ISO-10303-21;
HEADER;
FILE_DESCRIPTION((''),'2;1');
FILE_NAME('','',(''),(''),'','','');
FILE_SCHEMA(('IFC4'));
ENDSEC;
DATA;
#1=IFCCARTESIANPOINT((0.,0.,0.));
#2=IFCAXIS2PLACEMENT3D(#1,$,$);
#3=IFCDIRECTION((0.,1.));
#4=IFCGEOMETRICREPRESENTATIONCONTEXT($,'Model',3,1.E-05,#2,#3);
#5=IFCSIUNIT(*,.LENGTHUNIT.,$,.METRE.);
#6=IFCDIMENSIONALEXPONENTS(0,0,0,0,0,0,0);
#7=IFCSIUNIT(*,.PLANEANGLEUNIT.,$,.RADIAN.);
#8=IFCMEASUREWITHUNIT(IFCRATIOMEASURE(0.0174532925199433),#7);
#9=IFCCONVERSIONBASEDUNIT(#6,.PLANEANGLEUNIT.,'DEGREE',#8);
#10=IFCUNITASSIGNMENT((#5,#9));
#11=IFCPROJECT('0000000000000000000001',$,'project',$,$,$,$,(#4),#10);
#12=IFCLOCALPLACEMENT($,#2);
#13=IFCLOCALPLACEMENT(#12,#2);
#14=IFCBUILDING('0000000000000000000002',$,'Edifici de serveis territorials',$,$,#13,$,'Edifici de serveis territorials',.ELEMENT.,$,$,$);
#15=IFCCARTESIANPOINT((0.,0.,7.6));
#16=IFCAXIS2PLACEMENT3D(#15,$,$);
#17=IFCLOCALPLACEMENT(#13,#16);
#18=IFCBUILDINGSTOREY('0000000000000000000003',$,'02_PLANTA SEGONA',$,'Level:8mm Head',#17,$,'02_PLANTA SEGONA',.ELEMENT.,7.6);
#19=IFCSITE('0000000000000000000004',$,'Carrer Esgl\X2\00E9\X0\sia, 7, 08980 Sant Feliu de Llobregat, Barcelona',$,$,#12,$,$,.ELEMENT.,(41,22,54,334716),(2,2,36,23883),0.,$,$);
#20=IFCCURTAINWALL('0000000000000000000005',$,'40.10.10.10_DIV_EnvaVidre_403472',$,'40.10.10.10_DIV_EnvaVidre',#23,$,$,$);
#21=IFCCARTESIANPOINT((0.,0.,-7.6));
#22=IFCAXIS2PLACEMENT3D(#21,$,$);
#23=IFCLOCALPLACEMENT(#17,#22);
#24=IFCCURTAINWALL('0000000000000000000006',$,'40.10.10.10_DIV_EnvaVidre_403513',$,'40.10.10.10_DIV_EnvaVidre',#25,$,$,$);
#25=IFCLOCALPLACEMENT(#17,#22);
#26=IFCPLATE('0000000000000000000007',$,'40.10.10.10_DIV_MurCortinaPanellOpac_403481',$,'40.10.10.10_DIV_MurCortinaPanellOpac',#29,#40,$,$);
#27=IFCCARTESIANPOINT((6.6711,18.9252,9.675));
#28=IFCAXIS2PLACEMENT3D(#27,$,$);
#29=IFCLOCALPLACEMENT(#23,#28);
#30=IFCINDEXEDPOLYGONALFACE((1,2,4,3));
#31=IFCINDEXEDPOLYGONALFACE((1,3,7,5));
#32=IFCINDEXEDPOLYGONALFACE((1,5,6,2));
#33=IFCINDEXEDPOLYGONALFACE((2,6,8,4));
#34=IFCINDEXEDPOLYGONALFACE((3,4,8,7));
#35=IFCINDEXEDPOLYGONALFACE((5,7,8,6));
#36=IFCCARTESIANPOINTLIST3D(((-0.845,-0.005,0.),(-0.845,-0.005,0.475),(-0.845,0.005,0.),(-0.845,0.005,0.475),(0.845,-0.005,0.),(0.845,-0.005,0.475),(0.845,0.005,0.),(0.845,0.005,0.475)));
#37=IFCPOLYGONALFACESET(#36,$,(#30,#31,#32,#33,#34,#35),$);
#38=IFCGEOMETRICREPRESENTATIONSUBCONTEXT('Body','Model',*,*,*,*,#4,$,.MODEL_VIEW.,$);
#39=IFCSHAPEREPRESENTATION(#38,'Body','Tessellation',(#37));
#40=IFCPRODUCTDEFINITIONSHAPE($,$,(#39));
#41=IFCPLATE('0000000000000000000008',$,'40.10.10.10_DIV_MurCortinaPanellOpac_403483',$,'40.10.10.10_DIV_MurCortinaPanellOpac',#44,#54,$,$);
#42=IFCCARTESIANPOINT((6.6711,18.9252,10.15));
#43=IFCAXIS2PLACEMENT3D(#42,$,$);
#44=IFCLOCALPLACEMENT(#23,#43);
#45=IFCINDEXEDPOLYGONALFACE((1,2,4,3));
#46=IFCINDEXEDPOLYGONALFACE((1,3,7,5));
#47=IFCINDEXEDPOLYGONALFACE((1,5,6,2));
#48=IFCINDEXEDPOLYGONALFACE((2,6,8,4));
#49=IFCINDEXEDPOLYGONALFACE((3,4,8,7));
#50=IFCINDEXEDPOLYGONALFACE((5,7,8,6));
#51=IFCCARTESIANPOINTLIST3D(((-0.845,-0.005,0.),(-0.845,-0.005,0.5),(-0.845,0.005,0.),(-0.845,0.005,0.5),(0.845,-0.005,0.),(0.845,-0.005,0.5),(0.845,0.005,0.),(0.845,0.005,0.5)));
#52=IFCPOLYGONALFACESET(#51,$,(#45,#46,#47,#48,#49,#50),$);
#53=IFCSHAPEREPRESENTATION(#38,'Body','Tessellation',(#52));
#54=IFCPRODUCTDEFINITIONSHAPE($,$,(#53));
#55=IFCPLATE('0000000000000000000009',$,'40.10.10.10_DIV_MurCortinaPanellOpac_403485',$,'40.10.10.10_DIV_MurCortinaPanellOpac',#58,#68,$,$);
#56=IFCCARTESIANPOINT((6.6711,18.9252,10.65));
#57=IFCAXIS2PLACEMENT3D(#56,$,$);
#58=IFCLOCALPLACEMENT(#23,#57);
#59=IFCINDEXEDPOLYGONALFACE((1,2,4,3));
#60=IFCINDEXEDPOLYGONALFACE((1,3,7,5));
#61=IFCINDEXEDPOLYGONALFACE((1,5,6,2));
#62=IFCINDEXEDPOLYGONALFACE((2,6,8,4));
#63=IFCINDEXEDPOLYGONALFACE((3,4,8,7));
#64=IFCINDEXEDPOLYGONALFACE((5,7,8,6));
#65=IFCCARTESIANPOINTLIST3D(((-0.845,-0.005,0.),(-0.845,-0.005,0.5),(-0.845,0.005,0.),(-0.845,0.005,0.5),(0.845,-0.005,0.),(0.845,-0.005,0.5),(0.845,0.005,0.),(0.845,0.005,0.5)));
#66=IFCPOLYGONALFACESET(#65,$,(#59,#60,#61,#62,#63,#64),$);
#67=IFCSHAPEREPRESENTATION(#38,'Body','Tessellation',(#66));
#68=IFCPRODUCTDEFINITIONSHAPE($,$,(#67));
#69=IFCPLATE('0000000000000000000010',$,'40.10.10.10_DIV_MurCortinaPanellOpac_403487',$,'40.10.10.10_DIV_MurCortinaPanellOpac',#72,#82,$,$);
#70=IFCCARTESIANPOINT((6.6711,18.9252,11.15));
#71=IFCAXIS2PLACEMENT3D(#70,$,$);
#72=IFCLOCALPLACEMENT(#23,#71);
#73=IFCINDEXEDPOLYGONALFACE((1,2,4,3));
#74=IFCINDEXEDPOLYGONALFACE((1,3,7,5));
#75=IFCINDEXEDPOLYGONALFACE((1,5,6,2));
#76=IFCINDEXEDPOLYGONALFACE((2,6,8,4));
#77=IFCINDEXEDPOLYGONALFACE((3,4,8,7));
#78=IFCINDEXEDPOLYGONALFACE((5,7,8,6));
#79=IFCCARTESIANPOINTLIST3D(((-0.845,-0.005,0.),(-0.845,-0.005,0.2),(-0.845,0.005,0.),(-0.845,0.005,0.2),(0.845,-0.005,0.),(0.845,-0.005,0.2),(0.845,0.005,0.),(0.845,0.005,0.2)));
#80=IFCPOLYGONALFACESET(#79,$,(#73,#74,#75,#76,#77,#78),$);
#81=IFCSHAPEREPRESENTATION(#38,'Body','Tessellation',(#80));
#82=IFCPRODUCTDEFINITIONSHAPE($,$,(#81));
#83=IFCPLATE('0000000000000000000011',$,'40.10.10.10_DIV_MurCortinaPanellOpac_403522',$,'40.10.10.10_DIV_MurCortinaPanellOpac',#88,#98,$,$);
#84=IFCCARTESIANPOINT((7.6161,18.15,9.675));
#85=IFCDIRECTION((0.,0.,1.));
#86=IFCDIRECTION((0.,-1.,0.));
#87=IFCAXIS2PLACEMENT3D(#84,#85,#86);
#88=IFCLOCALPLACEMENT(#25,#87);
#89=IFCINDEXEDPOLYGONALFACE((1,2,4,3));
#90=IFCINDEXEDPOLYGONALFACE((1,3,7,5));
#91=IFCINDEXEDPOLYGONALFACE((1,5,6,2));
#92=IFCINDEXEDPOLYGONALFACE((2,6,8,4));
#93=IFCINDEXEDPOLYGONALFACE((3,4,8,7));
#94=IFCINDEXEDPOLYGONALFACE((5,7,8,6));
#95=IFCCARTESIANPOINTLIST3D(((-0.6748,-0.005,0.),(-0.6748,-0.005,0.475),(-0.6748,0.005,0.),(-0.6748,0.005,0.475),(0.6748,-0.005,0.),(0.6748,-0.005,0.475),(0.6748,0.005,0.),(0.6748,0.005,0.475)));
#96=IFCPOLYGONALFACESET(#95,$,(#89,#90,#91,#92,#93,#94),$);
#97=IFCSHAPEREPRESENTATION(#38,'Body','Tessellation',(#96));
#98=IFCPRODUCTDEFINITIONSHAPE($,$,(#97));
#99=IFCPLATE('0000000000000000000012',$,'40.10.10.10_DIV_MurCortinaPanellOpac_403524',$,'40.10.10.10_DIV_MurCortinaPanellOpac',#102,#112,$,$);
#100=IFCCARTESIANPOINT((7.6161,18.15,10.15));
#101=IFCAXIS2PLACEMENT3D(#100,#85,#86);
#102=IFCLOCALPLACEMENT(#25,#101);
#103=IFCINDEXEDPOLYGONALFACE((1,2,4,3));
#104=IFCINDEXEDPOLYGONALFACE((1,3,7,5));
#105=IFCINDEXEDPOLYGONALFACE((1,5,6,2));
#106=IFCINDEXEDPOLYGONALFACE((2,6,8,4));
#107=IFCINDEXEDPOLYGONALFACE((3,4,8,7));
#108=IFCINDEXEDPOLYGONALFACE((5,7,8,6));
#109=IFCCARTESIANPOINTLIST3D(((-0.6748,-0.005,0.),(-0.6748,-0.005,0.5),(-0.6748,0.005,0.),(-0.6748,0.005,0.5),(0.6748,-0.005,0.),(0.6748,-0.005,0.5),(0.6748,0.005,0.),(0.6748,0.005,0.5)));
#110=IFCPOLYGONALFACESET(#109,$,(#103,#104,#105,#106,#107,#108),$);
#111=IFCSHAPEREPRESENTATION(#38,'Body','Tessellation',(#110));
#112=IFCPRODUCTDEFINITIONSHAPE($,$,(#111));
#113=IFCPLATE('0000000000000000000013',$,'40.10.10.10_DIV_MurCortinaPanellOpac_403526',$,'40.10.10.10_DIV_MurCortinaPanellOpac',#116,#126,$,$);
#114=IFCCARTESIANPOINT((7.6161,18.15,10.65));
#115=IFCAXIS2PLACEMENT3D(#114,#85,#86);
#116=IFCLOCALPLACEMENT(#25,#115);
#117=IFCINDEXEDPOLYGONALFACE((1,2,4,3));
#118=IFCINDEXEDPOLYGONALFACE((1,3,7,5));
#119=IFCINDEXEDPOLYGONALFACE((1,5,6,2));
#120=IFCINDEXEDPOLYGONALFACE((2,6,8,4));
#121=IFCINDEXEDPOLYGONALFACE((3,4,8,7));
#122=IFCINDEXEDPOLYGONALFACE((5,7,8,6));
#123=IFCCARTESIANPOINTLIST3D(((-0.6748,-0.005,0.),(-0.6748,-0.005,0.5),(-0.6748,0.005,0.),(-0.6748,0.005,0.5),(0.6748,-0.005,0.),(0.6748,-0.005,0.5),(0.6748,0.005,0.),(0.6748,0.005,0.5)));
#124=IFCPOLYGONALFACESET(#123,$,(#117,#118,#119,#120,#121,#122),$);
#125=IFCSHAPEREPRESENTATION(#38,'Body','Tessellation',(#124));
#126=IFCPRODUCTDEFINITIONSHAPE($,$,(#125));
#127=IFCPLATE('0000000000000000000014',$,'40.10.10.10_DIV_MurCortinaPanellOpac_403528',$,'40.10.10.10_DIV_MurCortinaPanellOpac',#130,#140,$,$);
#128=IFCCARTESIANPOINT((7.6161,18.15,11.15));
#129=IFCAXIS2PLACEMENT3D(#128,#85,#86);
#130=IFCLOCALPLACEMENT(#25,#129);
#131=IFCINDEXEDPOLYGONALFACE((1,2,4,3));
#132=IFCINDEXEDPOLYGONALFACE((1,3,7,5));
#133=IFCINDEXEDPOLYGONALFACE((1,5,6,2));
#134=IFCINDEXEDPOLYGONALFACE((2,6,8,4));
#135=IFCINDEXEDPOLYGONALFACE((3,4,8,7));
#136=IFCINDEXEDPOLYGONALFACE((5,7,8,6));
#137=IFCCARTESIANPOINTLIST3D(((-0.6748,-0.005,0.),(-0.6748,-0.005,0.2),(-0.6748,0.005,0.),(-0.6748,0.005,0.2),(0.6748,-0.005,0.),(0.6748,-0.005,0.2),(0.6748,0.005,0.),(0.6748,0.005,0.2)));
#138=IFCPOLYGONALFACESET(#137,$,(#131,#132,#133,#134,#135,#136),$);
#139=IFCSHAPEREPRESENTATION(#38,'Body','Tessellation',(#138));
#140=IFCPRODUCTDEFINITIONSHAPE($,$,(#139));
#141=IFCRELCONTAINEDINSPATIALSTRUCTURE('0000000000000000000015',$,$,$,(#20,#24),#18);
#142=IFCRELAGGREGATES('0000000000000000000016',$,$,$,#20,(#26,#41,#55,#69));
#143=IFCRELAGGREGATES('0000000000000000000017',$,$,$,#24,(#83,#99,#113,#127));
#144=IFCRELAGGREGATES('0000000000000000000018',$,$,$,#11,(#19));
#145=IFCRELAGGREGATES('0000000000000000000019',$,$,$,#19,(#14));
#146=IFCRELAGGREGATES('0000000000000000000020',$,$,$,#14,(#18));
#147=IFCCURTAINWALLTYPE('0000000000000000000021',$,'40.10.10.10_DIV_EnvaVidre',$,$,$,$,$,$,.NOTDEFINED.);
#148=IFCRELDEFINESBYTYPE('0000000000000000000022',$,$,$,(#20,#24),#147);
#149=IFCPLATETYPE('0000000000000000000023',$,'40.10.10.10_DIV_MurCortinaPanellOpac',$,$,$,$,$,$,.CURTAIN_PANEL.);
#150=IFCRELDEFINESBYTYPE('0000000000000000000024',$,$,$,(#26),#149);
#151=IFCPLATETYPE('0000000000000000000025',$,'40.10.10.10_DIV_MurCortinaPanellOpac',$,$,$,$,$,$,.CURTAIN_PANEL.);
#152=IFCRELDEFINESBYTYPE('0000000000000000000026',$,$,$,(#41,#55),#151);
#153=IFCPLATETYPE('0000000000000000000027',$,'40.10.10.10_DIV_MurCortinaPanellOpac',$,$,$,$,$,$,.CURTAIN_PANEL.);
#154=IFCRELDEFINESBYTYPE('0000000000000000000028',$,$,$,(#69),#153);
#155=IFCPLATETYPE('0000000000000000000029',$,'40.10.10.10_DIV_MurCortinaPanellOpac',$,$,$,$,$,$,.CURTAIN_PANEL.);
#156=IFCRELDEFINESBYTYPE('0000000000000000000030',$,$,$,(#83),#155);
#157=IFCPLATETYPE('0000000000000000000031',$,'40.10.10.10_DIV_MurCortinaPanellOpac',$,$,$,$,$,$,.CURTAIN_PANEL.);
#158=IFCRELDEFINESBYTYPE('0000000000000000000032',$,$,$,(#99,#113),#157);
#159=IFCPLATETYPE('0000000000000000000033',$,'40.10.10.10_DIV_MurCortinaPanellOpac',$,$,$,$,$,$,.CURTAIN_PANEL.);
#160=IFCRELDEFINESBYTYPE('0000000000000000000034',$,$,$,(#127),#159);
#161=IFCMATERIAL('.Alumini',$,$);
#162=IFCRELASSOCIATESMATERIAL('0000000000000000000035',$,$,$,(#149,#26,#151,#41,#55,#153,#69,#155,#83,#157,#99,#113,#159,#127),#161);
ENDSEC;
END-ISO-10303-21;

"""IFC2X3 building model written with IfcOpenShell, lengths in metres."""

from ifc_helpers import new_model, entity, si_unit, converted_unit, direction, frame, origin, origin_2d_with_axis, place, context, subcontext, project, spatial, rectangle, extrude, source, transform, mapped, material, type_object, type_shapes, element, aggregate, save


model = new_model("IFC2X3")

# Units and contexts
model_context = context("Model", 3, precision=1e-05, world=origin(), true_north=direction((0.0, 1.0)))
body_context = subcontext(model_context, "Body", "Model", "MODEL_VIEW")
ifc_project = project(units=[si_unit("LENGTHUNIT", "METRE"), converted_unit("PLANEANGLEUNIT", "DEGREE", entity("IfcRatioMeasure", 0.0174532925199433), si_unit("PLANEANGLEUNIT", "RADIAN"), dimensions=[0, 0, 0, 0, 0, 0, 0])], contexts=[model_context])

# Site, building, storey
site_placement = place(None, origin())
site = spatial("IfcSite", under=ifc_project, at=site_placement, Name="Carrer Església, 7, 08980 Sant Feliu de Llobregat, Barcelona", CompositionType="ELEMENT", RefLatitude=(41, 22, 54, 334716), RefLongitude=(2, 2, 36, 23883), RefElevation=0.0)
building_placement = place(site_placement, origin())
building = spatial("IfcBuilding", under=site, at=building_placement, Name="Edifici de serveis territorials", LongName="Edifici de serveis territorials", CompositionType="ELEMENT")
storey_placement = place(building_placement, frame((0.0, 0.0, 7.6)))
storey = spatial("IfcBuildingStorey", under=building, at=storey_placement, Name="02_PLANTA SEGONA", ObjectType="Level:8mm Head", LongName="02_PLANTA SEGONA", CompositionType="ELEMENT", Elevation=7.6)

# Curtain walls
curtain_wall_type = type_object("IfcCurtainWallType", Name="40.10.10.10_DIV_EnvaVidre", PredefinedType="NOTDEFINED")
curtain_wall_1_placement = place(storey_placement, frame((0.0, 0.0, -7.6)))
curtain_wall_1 = element("IfcCurtainWall", 1, at=curtain_wall_1_placement, inside=storey, type_object=curtain_wall_type, Name="40.10.10.10_DIV_EnvaVidre_403472", ObjectType="40.10.10.10_DIV_EnvaVidre")
curtain_wall_2_placement = place(storey_placement, frame((0.0, 0.0, -7.6)))
curtain_wall_2 = element("IfcCurtainWall", 2, at=curtain_wall_2_placement, inside=storey, type_object=curtain_wall_type, Name="40.10.10.10_DIV_EnvaVidre_403513", ObjectType="40.10.10.10_DIV_EnvaVidre")

# Plates
ifc_material_1 = material(Name=".Alumini")
plate_type_1 = type_object("IfcPlateType", Name="40.10.10.10_DIV_MurCortinaPanellOpac", PredefinedType="CURTAIN_PANEL", material=ifc_material_1)
shared_shape_1 = source(origin(), body_context, "Body", "SweptSolid", [
    extrude(rectangle(XDim=0.01, YDim=1.69, at=origin_2d_with_axis()), frame((0.0, 0.0, 0.0), z_axis=(0.0, 0.0, 1.0), x_axis=(0.0, 1.0, 0.0)), (0.0, 0.0, 1.0), 0.475),
])
type_shapes(plate_type_1, [shared_shape_1])
plate_1_placement = place(curtain_wall_1_placement, frame((6.6711, 18.9252, 9.675)))
plate_1 = element("IfcPlate", 3, at=plate_1_placement, type_object=plate_type_1, material=ifc_material_1, Name="40.10.10.10_DIV_MurCortinaPanellOpac_403481", ObjectType="40.10.10.10_DIV_MurCortinaPanellOpac", context=body_context, shape_type="MappedRepresentation", body=[
    mapped(shared_shape_1, transform((0.0, 0.0, 0.0), scale=1.0)),
])
plate_type_2 = type_object("IfcPlateType", Name="40.10.10.10_DIV_MurCortinaPanellOpac", PredefinedType="CURTAIN_PANEL", material=ifc_material_1)
shared_shape_2 = source(origin(), body_context, "Body", "SweptSolid", [
    extrude(rectangle(XDim=0.01, YDim=1.69, at=origin_2d_with_axis()), frame((0.0, 0.0, 0.0), z_axis=(0.0, 0.0, 1.0), x_axis=(0.0, 1.0, 0.0)), (0.0, 0.0, 1.0), 0.5),
])
type_shapes(plate_type_2, [shared_shape_2])
plate_2_placement = place(curtain_wall_1_placement, frame((6.6711, 18.9252, 10.15)))
plate_2 = element("IfcPlate", 4, at=plate_2_placement, type_object=plate_type_2, material=ifc_material_1, Name="40.10.10.10_DIV_MurCortinaPanellOpac_403483", ObjectType="40.10.10.10_DIV_MurCortinaPanellOpac", context=body_context, shape_type="MappedRepresentation", body=[
    mapped(shared_shape_2, transform((0.0, 0.0, 0.0), scale=1.0)),
])
plate_3_placement = place(curtain_wall_1_placement, frame((6.6711, 18.9252, 10.65)))
plate_3 = element("IfcPlate", 5, at=plate_3_placement, type_object=plate_type_2, material=ifc_material_1, Name="40.10.10.10_DIV_MurCortinaPanellOpac_403485", ObjectType="40.10.10.10_DIV_MurCortinaPanellOpac", context=body_context, shape_type="MappedRepresentation", body=[
    mapped(shared_shape_2, transform((0.0, 0.0, 0.0), scale=1.0)),
])
plate_type_3 = type_object("IfcPlateType", Name="40.10.10.10_DIV_MurCortinaPanellOpac", PredefinedType="CURTAIN_PANEL", material=ifc_material_1)
shared_shape_3 = source(origin(), body_context, "Body", "SweptSolid", [
    extrude(rectangle(XDim=0.01, YDim=1.69, at=origin_2d_with_axis()), frame((0.0, 0.0, 0.0), z_axis=(0.0, 0.0, 1.0), x_axis=(0.0, 1.0, 0.0)), (0.0, 0.0, 1.0), 0.2),
])
type_shapes(plate_type_3, [shared_shape_3])
plate_4_placement = place(curtain_wall_1_placement, frame((6.6711, 18.9252, 11.15)))
plate_4 = element("IfcPlate", 6, at=plate_4_placement, type_object=plate_type_3, material=ifc_material_1, Name="40.10.10.10_DIV_MurCortinaPanellOpac_403487", ObjectType="40.10.10.10_DIV_MurCortinaPanellOpac", context=body_context, shape_type="MappedRepresentation", body=[
    mapped(shared_shape_3, transform((0.0, 0.0, 0.0), scale=1.0)),
])
aggregate(curtain_wall_1, [plate_1, plate_2, plate_3, plate_4])
plate_type_4 = type_object("IfcPlateType", Name="40.10.10.10_DIV_MurCortinaPanellOpac", PredefinedType="CURTAIN_PANEL", material=ifc_material_1)
shared_shape_4 = source(origin(), body_context, "Body", "SweptSolid", [
    extrude(rectangle(XDim=0.01, YDim=1.3496, at=origin_2d_with_axis()), frame((0.0, 0.0, 0.0), z_axis=(0.0, 0.0, 1.0), x_axis=(0.0, 1.0, 0.0)), (0.0, 0.0, 1.0), 0.475),
])
type_shapes(plate_type_4, [shared_shape_4])
plate_5_placement = place(curtain_wall_2_placement, frame((7.6161, 18.15, 9.675), z_axis=(0.0, 0.0, 1.0), x_axis=(0.0, -1.0, 0.0)))
plate_5 = element("IfcPlate", 7, at=plate_5_placement, type_object=plate_type_4, material=ifc_material_1, Name="40.10.10.10_DIV_MurCortinaPanellOpac_403522", ObjectType="40.10.10.10_DIV_MurCortinaPanellOpac", context=body_context, shape_type="MappedRepresentation", body=[
    mapped(shared_shape_4, transform((0.0, 0.0, 0.0), scale=1.0)),
])
plate_type_5 = type_object("IfcPlateType", Name="40.10.10.10_DIV_MurCortinaPanellOpac", PredefinedType="CURTAIN_PANEL", material=ifc_material_1)
shared_shape_5 = source(origin(), body_context, "Body", "SweptSolid", [
    extrude(rectangle(XDim=0.01, YDim=1.3496, at=origin_2d_with_axis()), frame((0.0, 0.0, 0.0), z_axis=(0.0, 0.0, 1.0), x_axis=(0.0, 1.0, 0.0)), (0.0, 0.0, 1.0), 0.5),
])
type_shapes(plate_type_5, [shared_shape_5])
plate_6_placement = place(curtain_wall_2_placement, frame((7.6161, 18.15, 10.15), z_axis=(0.0, 0.0, 1.0), x_axis=(0.0, -1.0, 0.0)))
plate_6 = element("IfcPlate", 8, at=plate_6_placement, type_object=plate_type_5, material=ifc_material_1, Name="40.10.10.10_DIV_MurCortinaPanellOpac_403524", ObjectType="40.10.10.10_DIV_MurCortinaPanellOpac", context=body_context, shape_type="MappedRepresentation", body=[
    mapped(shared_shape_5, transform((0.0, 0.0, 0.0), scale=1.0)),
])
plate_7_placement = place(curtain_wall_2_placement, frame((7.6161, 18.15, 10.65), z_axis=(0.0, 0.0, 1.0), x_axis=(0.0, -1.0, 0.0)))
plate_7 = element("IfcPlate", 9, at=plate_7_placement, type_object=plate_type_5, material=ifc_material_1, Name="40.10.10.10_DIV_MurCortinaPanellOpac_403526", ObjectType="40.10.10.10_DIV_MurCortinaPanellOpac", context=body_context, shape_type="MappedRepresentation", body=[
    mapped(shared_shape_5, transform((0.0, 0.0, 0.0), scale=1.0)),
])
plate_type_6 = type_object("IfcPlateType", Name="40.10.10.10_DIV_MurCortinaPanellOpac", PredefinedType="CURTAIN_PANEL", material=ifc_material_1)
shared_shape_6 = source(origin(), body_context, "Body", "SweptSolid", [
    extrude(rectangle(XDim=0.01, YDim=1.3496, at=origin_2d_with_axis()), frame((0.0, 0.0, 0.0), z_axis=(0.0, 0.0, 1.0), x_axis=(0.0, 1.0, 0.0)), (0.0, 0.0, 1.0), 0.2),
])
type_shapes(plate_type_6, [shared_shape_6])
plate_8_placement = place(curtain_wall_2_placement, frame((7.6161, 18.15, 11.15), z_axis=(0.0, 0.0, 1.0), x_axis=(0.0, -1.0, 0.0)))
plate_8 = element("IfcPlate", 10, at=plate_8_placement, type_object=plate_type_6, material=ifc_material_1, Name="40.10.10.10_DIV_MurCortinaPanellOpac_403528", ObjectType="40.10.10.10_DIV_MurCortinaPanellOpac", context=body_context, shape_type="MappedRepresentation", body=[
    mapped(shared_shape_6, transform((0.0, 0.0, 0.0), scale=1.0)),
])
aggregate(curtain_wall_2, [plate_5, plate_6, plate_7, plate_8])

save(model, "model.ifc")
